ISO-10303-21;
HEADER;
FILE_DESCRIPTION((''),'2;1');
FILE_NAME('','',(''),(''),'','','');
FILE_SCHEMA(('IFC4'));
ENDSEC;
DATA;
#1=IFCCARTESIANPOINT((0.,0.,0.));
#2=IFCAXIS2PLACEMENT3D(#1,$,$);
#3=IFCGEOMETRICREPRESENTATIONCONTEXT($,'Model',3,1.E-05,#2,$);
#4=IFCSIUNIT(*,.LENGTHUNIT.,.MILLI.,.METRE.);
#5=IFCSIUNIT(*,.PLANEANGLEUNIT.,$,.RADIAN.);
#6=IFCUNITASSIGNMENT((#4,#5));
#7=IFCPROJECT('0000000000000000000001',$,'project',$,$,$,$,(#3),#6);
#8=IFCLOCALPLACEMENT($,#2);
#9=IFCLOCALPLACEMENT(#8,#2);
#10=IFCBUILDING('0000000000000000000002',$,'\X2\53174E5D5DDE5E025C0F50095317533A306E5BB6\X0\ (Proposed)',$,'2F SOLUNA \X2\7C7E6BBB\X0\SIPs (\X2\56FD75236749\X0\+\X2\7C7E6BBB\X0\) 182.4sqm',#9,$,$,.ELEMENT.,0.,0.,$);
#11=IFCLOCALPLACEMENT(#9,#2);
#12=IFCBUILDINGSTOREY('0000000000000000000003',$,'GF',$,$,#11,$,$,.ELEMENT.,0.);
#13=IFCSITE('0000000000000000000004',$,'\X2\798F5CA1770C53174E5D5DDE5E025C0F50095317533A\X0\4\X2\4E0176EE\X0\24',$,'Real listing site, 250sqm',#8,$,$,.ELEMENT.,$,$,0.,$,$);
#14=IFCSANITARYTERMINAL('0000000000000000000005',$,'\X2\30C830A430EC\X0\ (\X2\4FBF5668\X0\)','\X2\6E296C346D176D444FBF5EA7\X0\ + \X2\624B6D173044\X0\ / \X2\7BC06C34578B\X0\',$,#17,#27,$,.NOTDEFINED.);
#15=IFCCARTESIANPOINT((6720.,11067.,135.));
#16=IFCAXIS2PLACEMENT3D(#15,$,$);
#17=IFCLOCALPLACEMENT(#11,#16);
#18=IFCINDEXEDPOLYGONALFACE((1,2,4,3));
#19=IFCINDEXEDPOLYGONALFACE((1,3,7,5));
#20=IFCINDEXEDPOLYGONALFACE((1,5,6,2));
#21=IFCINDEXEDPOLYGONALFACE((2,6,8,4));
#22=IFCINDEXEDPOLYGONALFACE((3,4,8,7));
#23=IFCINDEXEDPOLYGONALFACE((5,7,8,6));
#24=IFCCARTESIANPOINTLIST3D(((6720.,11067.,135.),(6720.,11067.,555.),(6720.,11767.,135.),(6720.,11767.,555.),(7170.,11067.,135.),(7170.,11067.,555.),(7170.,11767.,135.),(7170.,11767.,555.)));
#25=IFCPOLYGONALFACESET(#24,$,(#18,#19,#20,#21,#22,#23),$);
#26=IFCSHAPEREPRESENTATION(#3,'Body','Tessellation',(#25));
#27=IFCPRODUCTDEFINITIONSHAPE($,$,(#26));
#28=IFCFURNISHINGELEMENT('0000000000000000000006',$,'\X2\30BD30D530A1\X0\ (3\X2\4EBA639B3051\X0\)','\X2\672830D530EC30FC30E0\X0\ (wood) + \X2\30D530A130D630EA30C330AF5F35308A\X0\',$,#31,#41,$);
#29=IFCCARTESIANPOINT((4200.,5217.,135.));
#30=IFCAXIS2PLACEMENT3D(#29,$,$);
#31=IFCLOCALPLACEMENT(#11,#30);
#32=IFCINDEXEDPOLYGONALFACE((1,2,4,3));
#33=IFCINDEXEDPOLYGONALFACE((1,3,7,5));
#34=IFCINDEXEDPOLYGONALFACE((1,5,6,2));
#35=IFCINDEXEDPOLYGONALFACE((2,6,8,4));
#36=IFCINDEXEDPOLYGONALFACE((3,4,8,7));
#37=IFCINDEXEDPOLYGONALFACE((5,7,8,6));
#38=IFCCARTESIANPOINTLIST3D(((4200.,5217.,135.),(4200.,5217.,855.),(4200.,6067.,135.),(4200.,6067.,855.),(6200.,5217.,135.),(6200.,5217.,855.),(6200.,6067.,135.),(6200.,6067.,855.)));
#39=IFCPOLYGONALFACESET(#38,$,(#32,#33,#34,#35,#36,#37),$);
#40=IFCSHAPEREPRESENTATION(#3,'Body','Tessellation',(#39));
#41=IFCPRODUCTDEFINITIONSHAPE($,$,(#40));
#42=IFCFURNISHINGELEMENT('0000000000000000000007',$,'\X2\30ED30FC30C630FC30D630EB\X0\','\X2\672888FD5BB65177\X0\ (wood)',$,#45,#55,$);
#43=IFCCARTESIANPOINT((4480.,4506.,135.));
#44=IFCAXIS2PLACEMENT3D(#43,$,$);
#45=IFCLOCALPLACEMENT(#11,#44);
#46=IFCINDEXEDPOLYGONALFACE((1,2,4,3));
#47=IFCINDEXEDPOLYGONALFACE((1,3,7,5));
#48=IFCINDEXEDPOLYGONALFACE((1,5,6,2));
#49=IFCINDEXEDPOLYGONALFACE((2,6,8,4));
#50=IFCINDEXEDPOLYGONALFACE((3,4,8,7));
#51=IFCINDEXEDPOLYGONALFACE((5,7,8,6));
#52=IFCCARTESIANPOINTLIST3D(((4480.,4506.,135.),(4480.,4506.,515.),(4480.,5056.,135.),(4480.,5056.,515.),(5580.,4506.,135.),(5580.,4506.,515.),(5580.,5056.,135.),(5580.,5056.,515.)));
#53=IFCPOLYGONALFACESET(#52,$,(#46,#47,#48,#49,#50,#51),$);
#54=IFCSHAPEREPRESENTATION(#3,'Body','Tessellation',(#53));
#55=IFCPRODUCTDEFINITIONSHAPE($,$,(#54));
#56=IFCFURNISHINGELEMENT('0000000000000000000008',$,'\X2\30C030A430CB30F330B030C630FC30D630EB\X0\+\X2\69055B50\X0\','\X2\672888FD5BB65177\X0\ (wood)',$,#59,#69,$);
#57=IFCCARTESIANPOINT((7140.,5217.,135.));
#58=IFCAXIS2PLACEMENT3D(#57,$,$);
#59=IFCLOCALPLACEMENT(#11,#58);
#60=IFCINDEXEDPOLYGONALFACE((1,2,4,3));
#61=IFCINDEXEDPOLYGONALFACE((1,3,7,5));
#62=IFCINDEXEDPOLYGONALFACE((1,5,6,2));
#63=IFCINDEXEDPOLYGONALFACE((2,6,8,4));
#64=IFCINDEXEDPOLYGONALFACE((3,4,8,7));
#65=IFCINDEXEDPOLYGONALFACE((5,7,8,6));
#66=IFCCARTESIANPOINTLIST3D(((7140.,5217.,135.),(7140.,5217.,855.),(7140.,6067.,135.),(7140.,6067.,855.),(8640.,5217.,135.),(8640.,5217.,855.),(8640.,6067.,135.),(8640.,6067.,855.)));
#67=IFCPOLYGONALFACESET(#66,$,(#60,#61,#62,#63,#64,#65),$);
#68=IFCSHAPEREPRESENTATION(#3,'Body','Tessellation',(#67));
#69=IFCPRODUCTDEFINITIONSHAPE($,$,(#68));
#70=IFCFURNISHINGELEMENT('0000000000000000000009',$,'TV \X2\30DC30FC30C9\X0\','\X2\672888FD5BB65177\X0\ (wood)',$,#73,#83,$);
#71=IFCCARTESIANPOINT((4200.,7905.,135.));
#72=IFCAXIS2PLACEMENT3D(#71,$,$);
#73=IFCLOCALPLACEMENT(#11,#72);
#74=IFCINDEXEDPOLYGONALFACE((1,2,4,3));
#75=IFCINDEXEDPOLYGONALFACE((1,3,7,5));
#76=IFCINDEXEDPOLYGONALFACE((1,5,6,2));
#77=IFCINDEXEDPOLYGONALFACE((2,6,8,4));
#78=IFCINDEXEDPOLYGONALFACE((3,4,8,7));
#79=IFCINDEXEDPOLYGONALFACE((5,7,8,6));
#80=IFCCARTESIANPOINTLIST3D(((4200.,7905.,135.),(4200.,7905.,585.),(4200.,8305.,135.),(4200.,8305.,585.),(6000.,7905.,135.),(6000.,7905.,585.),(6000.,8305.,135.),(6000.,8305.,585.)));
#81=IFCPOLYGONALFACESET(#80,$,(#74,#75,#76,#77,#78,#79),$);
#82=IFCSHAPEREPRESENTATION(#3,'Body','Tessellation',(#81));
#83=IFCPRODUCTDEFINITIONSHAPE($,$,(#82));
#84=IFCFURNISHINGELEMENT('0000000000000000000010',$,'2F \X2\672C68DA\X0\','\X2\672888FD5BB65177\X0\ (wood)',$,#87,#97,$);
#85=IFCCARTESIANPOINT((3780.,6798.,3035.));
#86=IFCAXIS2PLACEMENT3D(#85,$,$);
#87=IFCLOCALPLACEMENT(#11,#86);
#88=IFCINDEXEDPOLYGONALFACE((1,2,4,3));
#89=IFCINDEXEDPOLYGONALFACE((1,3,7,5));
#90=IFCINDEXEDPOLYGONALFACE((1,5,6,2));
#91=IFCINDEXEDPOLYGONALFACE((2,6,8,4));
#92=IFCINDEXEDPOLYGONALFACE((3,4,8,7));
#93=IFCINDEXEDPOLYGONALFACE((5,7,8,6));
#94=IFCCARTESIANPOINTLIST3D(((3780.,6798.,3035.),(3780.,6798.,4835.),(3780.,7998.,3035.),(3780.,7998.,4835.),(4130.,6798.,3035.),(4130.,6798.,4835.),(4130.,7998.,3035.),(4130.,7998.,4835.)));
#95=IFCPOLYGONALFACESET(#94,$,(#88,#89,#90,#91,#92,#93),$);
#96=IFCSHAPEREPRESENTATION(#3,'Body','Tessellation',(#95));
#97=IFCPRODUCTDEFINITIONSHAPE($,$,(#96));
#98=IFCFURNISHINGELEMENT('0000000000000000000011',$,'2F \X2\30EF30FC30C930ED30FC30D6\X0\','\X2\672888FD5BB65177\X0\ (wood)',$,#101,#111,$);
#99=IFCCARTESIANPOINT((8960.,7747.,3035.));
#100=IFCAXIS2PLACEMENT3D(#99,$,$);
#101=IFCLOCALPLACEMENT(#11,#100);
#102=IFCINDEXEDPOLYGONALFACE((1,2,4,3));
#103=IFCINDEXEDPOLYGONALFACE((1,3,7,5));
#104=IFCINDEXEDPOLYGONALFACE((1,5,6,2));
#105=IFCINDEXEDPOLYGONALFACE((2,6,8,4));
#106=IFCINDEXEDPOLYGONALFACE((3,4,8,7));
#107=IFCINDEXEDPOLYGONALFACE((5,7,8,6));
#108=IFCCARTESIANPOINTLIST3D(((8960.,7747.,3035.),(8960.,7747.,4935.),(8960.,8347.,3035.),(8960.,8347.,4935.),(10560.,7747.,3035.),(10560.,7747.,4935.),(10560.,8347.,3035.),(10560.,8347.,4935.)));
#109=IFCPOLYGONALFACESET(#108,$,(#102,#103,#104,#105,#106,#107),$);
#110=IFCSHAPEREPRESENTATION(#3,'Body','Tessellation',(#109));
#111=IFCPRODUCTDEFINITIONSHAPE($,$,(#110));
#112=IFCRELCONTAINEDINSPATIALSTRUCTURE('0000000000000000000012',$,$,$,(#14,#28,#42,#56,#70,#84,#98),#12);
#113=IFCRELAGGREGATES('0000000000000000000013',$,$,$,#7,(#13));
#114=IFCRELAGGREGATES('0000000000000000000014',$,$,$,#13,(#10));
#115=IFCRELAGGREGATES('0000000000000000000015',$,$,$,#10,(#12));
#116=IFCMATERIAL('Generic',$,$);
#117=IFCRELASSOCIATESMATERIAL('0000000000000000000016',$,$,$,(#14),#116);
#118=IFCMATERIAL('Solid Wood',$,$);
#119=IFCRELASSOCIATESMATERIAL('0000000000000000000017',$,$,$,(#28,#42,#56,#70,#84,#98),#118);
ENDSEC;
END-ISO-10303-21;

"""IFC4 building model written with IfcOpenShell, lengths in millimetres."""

from ifc_helpers import new_model, si_unit, frame, frame_2d, origin, place, context, project, spatial, rectangle, extrude, material, element, save


model = new_model("IFC4")

# Units and contexts
model_context = context("Model", 3, precision=1e-05, world=origin())
ifc_project = project(units=[si_unit("LENGTHUNIT", "METRE", prefix="MILLI"), si_unit("PLANEANGLEUNIT", "RADIAN")], contexts=[model_context])

# Site, building, storey
site_placement = place(None, origin())
site = spatial("IfcSite", under=ifc_project, at=site_placement, Name="福岡県北九州市小倉北区4丁目24", ObjectType="Real listing site, 250sqm", CompositionType="ELEMENT", RefElevation=0.0)
building_placement = place(site_placement, origin())
building = spatial("IfcBuilding", under=site, at=building_placement, Name="北九州市小倉北区の家 (Proposed)", ObjectType="2F SOLUNA 籾殻SIPs (国産杉+籾殻) 182.4sqm", CompositionType="ELEMENT", ElevationOfRefHeight=0.0, ElevationOfTerrain=0.0)
storey_placement = place(building_placement, origin())
storey = spatial("IfcBuildingStorey", under=building, at=storey_placement, Name="GF", CompositionType="ELEMENT", Elevation=0.0)

# Shared definitions
ifc_material_1 = material(Name="Generic")

# Shared definitions
ifc_material_2 = material(Name="Solid Wood")

# Sanitary terminal
sanitary_terminal_1_placement = place(storey_placement, frame((6720.0, 11067.0, 135.0)))
element("IfcSanitaryTerminal", 1, at=sanitary_terminal_1_placement, inside=storey, material=ifc_material_1, Name="トイレ (便器)", Description="温水洗浄便座 + 手洗い / 節水型", PredefinedType="NOTDEFINED", context=model_context, shape_type="SweptSolid", body=[
    extrude(rectangle(XDim=450.0, YDim=700.0, at=frame_2d((225.0, 350.0))), frame((6720.0, 11067.0, 135.0)), (0.0, 0.0, 1.0), 420.0),
])

# Furnishing elements
furnishing_1_placement = place(storey_placement, frame((4200.0, 5217.0, 135.0)))
element("IfcFurnishingElement", 2, at=furnishing_1_placement, inside=storey, material=ifc_material_2, Name="ソファ (3人掛け)", Description="木フレーム (wood) + ファブリック張り", context=model_context, shape_type="SweptSolid", body=[
    extrude(rectangle(XDim=2000.0, YDim=850.0, at=frame_2d((1000.0, 425.0))), frame((4200.0, 5217.0, 135.0)), (0.0, 0.0, 1.0), 720.0),
])
furnishing_2_placement = place(storey_placement, frame((4480.0, 4506.0, 135.0)))
element("IfcFurnishingElement", 3, at=furnishing_2_placement, inside=storey, material=ifc_material_2, Name="ローテーブル", Description="木製家具 (wood)", context=model_context, shape_type="SweptSolid", body=[
    extrude(rectangle(XDim=1100.0, YDim=550.0, at=frame_2d((550.0, 275.0))), frame((4480.0, 4506.0, 135.0)), (0.0, 0.0, 1.0), 380.0),
])
furnishing_3_placement = place(storey_placement, frame((7140.0, 5217.0, 135.0)))
element("IfcFurnishingElement", 4, at=furnishing_3_placement, inside=storey, material=ifc_material_2, Name="ダイニングテーブル+椅子", Description="木製家具 (wood)", context=model_context, shape_type="SweptSolid", body=[
    extrude(rectangle(XDim=1500.0, YDim=850.0, at=frame_2d((750.0, 425.0))), frame((7140.0, 5217.0, 135.0)), (0.0, 0.0, 1.0), 720.0),
])
furnishing_4_placement = place(storey_placement, frame((4200.0, 7905.0, 135.0)))
element("IfcFurnishingElement", 5, at=furnishing_4_placement, inside=storey, material=ifc_material_2, Name="TV ボード", Description="木製家具 (wood)", context=model_context, shape_type="SweptSolid", body=[
    extrude(rectangle(XDim=1800.0, YDim=400.0, at=frame_2d((900.0, 200.0))), frame((4200.0, 7905.0, 135.0)), (0.0, 0.0, 1.0), 450.0),
])
furnishing_5_placement = place(storey_placement, frame((3780.0, 6798.0, 3035.0)))
element("IfcFurnishingElement", 6, at=furnishing_5_placement, inside=storey, material=ifc_material_2, Name="2F 本棚", Description="木製家具 (wood)", context=model_context, shape_type="SweptSolid", body=[
    extrude(rectangle(XDim=350.0, YDim=1200.0, at=frame_2d((175.0, 600.0))), frame((3780.0, 6798.0, 3035.0)), (0.0, 0.0, 1.0), 1800.0),
])
furnishing_6_placement = place(storey_placement, frame((8960.0, 7747.0, 3035.0)))
element("IfcFurnishingElement", 7, at=furnishing_6_placement, inside=storey, material=ifc_material_2, Name="2F ワードローブ", Description="木製家具 (wood)", context=model_context, shape_type="SweptSolid", body=[
    extrude(rectangle(XDim=1600.0, YDim=600.0, at=frame_2d((800.0, 300.0))), frame((8960.0, 7747.0, 3035.0)), (0.0, 0.0, 1.0), 1900.0),
])

save(model, "model.ifc")
